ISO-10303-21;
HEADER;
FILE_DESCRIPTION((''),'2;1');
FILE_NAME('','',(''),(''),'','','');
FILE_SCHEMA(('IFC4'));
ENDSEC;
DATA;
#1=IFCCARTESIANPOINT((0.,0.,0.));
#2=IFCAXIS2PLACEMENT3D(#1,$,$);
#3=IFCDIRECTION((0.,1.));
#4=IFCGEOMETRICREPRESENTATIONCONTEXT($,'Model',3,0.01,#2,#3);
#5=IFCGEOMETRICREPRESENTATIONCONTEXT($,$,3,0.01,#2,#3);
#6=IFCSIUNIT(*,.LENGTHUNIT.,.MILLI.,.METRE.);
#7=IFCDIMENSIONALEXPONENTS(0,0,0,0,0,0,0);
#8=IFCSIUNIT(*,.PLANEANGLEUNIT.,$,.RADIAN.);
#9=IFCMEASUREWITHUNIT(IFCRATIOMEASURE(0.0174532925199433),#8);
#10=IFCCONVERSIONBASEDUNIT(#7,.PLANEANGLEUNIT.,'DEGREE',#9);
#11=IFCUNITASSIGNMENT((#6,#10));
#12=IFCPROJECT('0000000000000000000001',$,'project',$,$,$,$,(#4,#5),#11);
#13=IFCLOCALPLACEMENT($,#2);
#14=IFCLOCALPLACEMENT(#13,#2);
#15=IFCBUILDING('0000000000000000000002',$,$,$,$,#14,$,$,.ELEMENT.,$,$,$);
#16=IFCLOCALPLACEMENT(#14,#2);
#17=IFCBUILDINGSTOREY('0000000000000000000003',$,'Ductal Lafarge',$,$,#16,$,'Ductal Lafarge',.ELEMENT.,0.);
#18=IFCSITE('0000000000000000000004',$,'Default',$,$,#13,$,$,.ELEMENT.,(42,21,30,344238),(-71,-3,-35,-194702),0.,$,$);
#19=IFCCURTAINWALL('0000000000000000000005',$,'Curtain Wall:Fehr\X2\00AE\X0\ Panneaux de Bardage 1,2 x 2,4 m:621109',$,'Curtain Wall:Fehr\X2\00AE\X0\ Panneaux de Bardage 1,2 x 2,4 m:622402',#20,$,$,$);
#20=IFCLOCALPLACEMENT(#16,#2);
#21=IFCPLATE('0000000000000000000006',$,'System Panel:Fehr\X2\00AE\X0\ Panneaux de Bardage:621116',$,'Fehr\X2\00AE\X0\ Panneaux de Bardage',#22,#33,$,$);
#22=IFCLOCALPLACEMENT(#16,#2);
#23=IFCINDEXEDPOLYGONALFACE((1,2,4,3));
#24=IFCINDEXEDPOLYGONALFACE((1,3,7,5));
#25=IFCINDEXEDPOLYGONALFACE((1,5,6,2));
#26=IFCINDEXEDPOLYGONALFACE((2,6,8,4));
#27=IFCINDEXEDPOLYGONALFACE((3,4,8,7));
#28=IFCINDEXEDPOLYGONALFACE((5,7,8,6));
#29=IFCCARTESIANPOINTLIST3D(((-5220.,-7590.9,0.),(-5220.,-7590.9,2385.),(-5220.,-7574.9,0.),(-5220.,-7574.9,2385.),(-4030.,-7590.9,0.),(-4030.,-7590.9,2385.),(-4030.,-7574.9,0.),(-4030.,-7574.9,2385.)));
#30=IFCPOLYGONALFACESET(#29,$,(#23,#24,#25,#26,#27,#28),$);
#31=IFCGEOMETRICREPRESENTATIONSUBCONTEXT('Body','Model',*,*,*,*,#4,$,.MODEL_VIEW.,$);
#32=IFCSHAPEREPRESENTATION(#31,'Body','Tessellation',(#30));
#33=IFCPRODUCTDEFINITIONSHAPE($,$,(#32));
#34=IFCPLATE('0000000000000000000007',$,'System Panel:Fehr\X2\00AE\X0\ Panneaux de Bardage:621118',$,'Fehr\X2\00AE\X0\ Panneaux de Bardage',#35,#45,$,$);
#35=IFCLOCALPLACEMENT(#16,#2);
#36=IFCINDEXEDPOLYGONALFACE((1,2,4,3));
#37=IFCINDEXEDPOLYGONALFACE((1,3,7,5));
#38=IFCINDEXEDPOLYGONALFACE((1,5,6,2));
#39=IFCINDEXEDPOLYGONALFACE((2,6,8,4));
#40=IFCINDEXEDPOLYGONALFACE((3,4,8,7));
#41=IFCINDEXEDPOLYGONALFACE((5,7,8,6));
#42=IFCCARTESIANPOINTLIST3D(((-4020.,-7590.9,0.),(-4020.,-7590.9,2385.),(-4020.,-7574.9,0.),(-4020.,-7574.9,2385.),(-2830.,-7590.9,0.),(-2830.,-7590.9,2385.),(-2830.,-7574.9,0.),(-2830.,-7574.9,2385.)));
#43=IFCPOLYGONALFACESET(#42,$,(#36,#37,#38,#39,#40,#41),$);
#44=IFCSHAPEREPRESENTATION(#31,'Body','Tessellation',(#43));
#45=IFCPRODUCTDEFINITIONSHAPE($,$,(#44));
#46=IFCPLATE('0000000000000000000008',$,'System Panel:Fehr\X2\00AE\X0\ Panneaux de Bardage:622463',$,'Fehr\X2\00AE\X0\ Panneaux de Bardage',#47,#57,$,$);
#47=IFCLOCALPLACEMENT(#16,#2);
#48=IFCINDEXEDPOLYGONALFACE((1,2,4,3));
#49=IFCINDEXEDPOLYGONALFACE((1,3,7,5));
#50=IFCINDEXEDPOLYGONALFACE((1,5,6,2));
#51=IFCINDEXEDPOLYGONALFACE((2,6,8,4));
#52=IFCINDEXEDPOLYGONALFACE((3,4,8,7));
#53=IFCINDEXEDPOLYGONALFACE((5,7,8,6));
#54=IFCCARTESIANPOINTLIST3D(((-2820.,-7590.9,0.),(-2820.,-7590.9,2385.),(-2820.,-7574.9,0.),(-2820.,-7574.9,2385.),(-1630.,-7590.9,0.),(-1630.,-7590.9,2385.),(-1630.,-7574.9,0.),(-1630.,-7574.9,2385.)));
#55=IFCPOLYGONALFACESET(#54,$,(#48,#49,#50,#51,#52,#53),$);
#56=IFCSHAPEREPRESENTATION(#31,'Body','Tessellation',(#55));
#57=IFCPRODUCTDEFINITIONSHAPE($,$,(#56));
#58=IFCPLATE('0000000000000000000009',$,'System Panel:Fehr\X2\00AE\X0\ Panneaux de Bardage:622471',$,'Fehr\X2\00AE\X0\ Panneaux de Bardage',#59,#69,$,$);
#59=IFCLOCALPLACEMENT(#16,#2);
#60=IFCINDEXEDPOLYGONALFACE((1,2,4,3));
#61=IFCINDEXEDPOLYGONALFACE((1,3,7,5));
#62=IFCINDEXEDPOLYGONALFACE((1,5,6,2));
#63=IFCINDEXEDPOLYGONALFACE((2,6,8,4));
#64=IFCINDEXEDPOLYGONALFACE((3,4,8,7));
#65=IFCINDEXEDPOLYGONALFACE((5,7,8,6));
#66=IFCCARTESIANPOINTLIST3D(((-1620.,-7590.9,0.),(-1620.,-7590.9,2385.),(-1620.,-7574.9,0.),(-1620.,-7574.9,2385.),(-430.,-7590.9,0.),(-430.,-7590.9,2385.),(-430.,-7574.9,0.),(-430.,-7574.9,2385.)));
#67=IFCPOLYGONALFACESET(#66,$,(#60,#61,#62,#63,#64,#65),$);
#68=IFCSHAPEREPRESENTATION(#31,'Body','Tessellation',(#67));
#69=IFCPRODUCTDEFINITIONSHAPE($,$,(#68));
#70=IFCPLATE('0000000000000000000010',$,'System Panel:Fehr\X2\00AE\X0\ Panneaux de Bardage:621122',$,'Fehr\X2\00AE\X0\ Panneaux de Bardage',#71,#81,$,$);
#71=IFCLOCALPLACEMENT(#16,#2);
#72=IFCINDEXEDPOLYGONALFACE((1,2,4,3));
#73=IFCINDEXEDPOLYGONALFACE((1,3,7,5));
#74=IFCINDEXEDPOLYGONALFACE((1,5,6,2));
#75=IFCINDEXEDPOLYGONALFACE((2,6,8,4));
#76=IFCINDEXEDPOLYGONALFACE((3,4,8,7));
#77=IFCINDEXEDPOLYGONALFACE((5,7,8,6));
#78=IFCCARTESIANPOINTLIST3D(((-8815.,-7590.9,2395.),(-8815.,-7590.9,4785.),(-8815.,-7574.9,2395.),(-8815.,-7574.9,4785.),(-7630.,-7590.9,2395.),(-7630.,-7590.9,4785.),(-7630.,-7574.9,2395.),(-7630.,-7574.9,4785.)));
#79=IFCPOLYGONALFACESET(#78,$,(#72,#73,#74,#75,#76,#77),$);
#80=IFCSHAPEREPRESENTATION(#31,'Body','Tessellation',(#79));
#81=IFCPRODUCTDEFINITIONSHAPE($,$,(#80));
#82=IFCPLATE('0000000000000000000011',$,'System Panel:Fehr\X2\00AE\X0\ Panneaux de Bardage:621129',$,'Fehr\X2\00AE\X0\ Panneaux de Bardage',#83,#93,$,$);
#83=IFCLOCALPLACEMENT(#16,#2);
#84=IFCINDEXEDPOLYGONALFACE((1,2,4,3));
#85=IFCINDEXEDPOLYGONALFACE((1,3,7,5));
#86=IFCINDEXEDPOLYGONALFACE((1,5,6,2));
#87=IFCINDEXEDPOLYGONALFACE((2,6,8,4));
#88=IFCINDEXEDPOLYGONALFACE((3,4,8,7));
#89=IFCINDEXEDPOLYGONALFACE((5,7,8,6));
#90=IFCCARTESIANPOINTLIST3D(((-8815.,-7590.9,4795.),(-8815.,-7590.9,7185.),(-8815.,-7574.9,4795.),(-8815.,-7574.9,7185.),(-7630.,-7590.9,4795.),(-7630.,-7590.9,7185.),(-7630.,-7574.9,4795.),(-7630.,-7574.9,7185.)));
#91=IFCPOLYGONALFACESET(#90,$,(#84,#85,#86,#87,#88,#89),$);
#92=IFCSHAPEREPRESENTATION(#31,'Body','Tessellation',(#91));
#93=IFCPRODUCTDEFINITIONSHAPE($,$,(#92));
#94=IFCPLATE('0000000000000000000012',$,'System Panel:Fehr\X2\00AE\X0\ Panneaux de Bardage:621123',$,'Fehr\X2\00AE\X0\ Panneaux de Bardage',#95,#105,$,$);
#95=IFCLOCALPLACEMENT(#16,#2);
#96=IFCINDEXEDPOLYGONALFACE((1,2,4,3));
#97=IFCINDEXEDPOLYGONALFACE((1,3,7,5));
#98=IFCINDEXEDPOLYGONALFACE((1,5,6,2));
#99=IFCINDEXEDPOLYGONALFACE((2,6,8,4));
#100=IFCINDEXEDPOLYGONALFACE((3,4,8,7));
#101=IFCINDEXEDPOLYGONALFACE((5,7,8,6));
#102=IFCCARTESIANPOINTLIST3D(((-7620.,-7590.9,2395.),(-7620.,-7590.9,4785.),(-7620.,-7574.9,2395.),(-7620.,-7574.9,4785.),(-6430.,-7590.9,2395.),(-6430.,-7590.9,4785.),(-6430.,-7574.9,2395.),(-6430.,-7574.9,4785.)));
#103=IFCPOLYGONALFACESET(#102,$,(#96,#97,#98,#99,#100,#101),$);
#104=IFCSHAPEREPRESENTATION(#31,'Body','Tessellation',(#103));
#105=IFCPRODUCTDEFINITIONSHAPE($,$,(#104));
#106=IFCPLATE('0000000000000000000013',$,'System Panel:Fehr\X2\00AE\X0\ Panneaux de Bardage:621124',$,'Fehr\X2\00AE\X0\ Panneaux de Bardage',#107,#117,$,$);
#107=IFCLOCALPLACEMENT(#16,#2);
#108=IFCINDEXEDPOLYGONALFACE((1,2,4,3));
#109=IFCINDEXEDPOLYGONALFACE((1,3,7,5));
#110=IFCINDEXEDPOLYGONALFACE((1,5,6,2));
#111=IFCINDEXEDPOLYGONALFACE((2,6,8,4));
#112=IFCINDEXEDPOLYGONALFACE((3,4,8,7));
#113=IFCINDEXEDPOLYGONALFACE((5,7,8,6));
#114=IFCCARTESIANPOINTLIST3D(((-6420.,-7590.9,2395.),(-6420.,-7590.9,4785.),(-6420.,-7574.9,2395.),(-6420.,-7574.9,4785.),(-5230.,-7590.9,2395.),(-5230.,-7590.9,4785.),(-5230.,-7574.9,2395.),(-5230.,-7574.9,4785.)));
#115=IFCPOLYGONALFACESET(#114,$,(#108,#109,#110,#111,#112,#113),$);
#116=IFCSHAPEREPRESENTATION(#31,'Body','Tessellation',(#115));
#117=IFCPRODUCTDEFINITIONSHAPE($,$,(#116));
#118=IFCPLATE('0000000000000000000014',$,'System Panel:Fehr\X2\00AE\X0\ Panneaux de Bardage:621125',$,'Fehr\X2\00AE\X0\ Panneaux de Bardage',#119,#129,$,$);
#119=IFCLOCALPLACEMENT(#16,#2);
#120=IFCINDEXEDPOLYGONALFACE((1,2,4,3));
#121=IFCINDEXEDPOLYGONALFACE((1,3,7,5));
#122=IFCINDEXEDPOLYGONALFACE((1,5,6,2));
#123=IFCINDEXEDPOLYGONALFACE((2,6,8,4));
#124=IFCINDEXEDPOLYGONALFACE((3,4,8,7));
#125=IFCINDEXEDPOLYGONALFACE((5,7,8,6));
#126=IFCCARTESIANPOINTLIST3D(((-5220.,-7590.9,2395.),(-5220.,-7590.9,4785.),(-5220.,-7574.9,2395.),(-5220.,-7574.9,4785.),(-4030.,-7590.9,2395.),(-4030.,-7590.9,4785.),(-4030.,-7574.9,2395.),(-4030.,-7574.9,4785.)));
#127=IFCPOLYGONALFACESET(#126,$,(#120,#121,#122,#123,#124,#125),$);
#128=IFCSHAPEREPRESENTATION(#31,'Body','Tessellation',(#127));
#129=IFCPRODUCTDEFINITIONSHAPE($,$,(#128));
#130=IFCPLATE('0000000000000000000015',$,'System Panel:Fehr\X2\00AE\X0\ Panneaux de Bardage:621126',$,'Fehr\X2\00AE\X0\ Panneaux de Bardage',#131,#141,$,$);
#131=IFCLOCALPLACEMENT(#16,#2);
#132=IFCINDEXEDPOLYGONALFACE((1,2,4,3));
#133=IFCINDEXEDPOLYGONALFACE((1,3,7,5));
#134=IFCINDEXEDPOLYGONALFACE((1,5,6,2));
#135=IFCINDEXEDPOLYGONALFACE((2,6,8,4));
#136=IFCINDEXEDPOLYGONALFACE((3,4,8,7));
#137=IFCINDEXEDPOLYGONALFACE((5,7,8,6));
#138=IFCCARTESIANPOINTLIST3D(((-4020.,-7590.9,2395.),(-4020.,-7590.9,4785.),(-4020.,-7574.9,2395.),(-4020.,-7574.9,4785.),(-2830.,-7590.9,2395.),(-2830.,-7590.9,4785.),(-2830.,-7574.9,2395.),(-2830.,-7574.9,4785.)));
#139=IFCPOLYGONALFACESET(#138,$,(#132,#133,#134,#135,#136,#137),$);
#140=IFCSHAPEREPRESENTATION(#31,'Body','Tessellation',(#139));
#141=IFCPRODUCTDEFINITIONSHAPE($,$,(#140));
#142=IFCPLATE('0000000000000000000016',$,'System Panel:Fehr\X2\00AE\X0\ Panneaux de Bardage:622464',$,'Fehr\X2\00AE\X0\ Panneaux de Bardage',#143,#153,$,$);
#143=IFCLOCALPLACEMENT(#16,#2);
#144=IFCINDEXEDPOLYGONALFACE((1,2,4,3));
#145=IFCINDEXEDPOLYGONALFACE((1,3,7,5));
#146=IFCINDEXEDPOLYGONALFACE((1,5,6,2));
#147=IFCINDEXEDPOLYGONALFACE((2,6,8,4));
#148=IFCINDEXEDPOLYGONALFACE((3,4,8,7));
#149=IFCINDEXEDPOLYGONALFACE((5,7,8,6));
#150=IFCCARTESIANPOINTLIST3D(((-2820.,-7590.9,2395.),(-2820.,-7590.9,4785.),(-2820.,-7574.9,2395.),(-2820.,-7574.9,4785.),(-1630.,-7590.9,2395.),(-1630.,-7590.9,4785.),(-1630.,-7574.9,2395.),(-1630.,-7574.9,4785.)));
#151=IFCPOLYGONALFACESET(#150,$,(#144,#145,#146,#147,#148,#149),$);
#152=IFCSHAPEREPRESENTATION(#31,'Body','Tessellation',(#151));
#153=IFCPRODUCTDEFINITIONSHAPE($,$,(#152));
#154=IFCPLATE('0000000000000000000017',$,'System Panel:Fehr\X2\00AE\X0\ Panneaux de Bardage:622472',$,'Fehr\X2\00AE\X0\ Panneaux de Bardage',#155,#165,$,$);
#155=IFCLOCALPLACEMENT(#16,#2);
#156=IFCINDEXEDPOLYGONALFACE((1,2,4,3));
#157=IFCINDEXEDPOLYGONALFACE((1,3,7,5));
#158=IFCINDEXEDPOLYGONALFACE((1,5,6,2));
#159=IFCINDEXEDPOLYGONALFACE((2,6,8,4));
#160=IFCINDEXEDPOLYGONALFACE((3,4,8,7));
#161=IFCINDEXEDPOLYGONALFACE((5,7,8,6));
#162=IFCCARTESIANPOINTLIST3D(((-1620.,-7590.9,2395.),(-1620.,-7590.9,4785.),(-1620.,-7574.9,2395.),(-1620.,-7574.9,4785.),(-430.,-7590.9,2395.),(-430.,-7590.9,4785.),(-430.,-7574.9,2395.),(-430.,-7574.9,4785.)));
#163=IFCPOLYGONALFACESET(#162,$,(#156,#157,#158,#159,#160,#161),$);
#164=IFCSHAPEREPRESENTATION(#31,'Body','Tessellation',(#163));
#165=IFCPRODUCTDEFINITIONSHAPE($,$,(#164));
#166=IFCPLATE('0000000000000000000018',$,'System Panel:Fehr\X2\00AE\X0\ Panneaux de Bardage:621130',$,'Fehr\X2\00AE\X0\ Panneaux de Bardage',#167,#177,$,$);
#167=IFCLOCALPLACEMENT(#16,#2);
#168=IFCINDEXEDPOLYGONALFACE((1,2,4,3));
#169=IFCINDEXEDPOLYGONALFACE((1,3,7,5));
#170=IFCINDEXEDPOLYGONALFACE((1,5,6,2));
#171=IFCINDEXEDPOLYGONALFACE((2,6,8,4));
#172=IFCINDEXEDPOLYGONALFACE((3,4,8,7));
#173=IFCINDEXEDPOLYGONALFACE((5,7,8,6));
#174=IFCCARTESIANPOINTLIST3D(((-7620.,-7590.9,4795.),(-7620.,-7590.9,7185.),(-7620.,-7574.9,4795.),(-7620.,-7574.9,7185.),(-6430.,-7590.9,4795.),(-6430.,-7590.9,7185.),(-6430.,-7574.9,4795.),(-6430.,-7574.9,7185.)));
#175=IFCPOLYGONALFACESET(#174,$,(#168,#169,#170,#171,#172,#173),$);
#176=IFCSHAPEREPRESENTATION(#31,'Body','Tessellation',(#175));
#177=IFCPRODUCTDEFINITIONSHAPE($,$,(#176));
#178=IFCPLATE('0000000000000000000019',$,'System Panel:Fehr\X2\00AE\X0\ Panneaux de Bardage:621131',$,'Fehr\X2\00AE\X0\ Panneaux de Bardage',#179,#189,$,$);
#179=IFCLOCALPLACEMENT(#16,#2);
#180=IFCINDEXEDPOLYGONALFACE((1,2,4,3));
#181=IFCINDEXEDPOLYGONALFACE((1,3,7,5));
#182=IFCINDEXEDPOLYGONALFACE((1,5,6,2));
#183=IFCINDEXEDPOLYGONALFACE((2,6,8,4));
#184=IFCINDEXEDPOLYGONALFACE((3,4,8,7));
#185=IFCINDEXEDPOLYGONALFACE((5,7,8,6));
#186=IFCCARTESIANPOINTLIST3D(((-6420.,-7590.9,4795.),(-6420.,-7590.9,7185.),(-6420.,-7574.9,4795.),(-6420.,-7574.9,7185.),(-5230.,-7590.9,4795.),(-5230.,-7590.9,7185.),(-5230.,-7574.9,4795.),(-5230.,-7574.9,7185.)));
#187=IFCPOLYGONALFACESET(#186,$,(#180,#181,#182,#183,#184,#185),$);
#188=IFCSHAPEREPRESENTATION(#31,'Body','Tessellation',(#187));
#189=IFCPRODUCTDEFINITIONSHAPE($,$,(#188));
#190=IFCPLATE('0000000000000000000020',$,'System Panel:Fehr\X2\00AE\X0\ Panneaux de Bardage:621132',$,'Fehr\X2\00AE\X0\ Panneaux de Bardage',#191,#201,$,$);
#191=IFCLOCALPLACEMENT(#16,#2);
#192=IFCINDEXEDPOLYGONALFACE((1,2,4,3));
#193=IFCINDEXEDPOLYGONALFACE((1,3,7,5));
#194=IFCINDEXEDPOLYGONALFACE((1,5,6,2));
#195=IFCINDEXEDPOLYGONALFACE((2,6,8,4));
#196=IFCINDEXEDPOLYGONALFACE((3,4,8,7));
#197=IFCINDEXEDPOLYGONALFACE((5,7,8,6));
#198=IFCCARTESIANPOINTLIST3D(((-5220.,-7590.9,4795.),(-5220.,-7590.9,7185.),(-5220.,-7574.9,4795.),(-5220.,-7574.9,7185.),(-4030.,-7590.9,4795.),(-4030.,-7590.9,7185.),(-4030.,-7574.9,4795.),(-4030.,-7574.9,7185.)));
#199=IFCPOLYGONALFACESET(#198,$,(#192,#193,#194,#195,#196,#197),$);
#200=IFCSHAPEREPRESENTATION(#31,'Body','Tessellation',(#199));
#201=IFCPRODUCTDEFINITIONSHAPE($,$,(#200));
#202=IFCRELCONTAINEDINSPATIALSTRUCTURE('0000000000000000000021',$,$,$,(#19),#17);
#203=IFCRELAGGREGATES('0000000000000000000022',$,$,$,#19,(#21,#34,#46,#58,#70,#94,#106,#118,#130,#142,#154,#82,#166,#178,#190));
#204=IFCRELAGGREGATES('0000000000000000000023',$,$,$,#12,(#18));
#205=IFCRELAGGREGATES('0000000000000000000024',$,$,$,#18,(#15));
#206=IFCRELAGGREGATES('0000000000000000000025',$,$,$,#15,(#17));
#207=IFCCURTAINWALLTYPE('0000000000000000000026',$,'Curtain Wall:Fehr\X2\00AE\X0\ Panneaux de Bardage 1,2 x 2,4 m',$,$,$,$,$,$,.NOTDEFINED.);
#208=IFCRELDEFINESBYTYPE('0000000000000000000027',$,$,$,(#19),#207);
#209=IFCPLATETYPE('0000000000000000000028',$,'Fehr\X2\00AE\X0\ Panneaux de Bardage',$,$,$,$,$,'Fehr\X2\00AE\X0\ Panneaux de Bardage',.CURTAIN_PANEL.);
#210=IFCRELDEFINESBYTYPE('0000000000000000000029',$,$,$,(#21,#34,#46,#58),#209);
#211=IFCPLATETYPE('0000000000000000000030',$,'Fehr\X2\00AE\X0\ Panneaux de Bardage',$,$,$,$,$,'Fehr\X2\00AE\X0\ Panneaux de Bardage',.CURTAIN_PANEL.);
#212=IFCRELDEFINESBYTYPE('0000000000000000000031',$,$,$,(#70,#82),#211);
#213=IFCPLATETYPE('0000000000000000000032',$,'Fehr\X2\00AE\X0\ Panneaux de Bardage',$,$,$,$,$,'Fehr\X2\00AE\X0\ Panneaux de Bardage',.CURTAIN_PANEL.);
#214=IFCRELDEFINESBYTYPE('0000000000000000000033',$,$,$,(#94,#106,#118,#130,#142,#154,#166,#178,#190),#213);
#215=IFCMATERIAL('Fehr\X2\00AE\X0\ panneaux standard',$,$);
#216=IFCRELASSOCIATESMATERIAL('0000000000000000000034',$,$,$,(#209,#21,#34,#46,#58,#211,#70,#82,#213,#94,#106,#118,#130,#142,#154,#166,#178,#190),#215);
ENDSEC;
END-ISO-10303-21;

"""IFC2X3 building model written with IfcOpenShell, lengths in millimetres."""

from ifc_helpers import new_model, entity, si_unit, converted_unit, direction, frame, origin, origin_2d_with_axis, place, context, subcontext, project, spatial, rectangle, extrude, source, transform, mapped, material, type_object, type_shapes, element, aggregate, save


model = new_model("IFC2X3")

# Units and contexts
model_context = context("Model", 3, precision=0.01, world=origin(), true_north=direction((0.0, 1.0)))
context_of_model = context(None, 3, precision=0.01, world=origin(), true_north=direction((0.0, 1.0)))
body_context = subcontext(model_context, "Body", "Model", "MODEL_VIEW")
ifc_project = project(units=[si_unit("LENGTHUNIT", "METRE", prefix="MILLI"), converted_unit("PLANEANGLEUNIT", "DEGREE", entity("IfcRatioMeasure", 0.0174532925199433), si_unit("PLANEANGLEUNIT", "RADIAN"), dimensions=[0, 0, 0, 0, 0, 0, 0])], contexts=[model_context, context_of_model])

# Site, building, storey
site_placement = place(None, origin())
site = spatial("IfcSite", under=ifc_project, at=site_placement, Name="Default", CompositionType="ELEMENT", RefLatitude=(42, 21, 30, 344238), RefLongitude=(-71, -3, -35, -194702), RefElevation=0.0)
building_placement = place(site_placement, origin())
building = spatial("IfcBuilding", under=site, at=building_placement, CompositionType="ELEMENT")
storey_placement = place(building_placement, origin())
storey = spatial("IfcBuildingStorey", under=building, at=storey_placement, Name="Ductal Lafarge", LongName="Ductal Lafarge", CompositionType="ELEMENT", Elevation=0.0)

# Curtain wall
ifc_material_1 = material(Name="Fehr® panneaux standard")
curtain_wall_type_1 = type_object("IfcCurtainWallType", Name="Curtain Wall:Fehr® Panneaux de Bardage 1,2 x 2,4 m", PredefinedType="NOTDEFINED")
curtain_wall_1_placement = place(storey_placement, origin())
curtain_wall_1 = element("IfcCurtainWall", 1, at=curtain_wall_1_placement, inside=storey, type_object=curtain_wall_type_1, Name="Curtain Wall:Fehr® Panneaux de Bardage 1,2 x 2,4 m:621109", ObjectType="Curtain Wall:Fehr® Panneaux de Bardage 1,2 x 2,4 m:622402")

# Plates
plate_type_1 = type_object("IfcPlateType", Name="Fehr® Panneaux de Bardage", ElementType="Fehr® Panneaux de Bardage", PredefinedType="CURTAIN_PANEL", material=ifc_material_1)
shared_shape_1 = source(origin(), body_context, "Body", "SweptSolid", [
    extrude(rectangle(XDim=16.0, YDim=1190.0, at=origin_2d_with_axis()), frame((0.0, 0.0, 0.0), z_axis=(0.0, 0.0, 1.0), x_axis=(0.0, 1.0, 0.0)), (0.0, 0.0, 1.0), 2385.0),
])
type_shapes(plate_type_1, [shared_shape_1])
plate_1_placement = place(curtain_wall_1_placement, frame((-4625.0, -7582.9, 0.0)))
plate_1 = element("IfcPlate", 2, at=plate_1_placement, type_object=plate_type_1, material=ifc_material_1, Name="System Panel:Fehr® Panneaux de Bardage:621116", ObjectType="Fehr® Panneaux de Bardage", context=body_context, shape_type="MappedRepresentation", body=[
    mapped(shared_shape_1, transform((0.0, 0.0, 0.0), scale=1.0)),
])
plate_2_placement = place(curtain_wall_1_placement, frame((-3425.0, -7582.9, 0.0)))
plate_2 = element("IfcPlate", 3, at=plate_2_placement, type_object=plate_type_1, material=ifc_material_1, Name="System Panel:Fehr® Panneaux de Bardage:621118", ObjectType="Fehr® Panneaux de Bardage", context=body_context, shape_type="MappedRepresentation", body=[
    mapped(shared_shape_1, transform((0.0, 0.0, 0.0), scale=1.0)),
])
plate_3_placement = place(curtain_wall_1_placement, frame((-2225.0, -7582.9, 0.0)))
plate_3 = element("IfcPlate", 4, at=plate_3_placement, type_object=plate_type_1, material=ifc_material_1, Name="System Panel:Fehr® Panneaux de Bardage:622463", ObjectType="Fehr® Panneaux de Bardage", context=body_context, shape_type="MappedRepresentation", body=[
    mapped(shared_shape_1, transform((0.0, 0.0, 0.0), scale=1.0)),
])
plate_4_placement = place(curtain_wall_1_placement, frame((-1025.0, -7582.9, 0.0)))
plate_4 = element("IfcPlate", 5, at=plate_4_placement, type_object=plate_type_1, material=ifc_material_1, Name="System Panel:Fehr® Panneaux de Bardage:622471", ObjectType="Fehr® Panneaux de Bardage", context=body_context, shape_type="MappedRepresentation", body=[
    mapped(shared_shape_1, transform((0.0, 0.0, 0.0), scale=1.0)),
])
plate_type_2 = type_object("IfcPlateType", Name="Fehr® Panneaux de Bardage", ElementType="Fehr® Panneaux de Bardage", PredefinedType="CURTAIN_PANEL", material=ifc_material_1)
shared_shape_2 = source(origin(), body_context, "Body", "SweptSolid", [
    extrude(rectangle(XDim=16.0, YDim=1185.0, at=origin_2d_with_axis()), frame((0.0, 0.0, 0.0), z_axis=(0.0, 0.0, 1.0), x_axis=(0.0, 1.0, 0.0)), (0.0, 0.0, 1.0), 2390.0),
])
type_shapes(plate_type_2, [shared_shape_2])
plate_5_placement = place(curtain_wall_1_placement, frame((-8222.5, -7582.9, 2395.0)))
plate_5 = element("IfcPlate", 6, at=plate_5_placement, type_object=plate_type_2, material=ifc_material_1, Name="System Panel:Fehr® Panneaux de Bardage:621122", ObjectType="Fehr® Panneaux de Bardage", context=body_context, shape_type="MappedRepresentation", body=[
    mapped(shared_shape_2, transform((0.0, 0.0, 0.0), scale=1.0)),
])
plate_6_placement = place(curtain_wall_1_placement, frame((-8222.5, -7582.9, 4795.0)))
plate_6 = element("IfcPlate", 7, at=plate_6_placement, type_object=plate_type_2, material=ifc_material_1, Name="System Panel:Fehr® Panneaux de Bardage:621129", ObjectType="Fehr® Panneaux de Bardage", context=body_context, shape_type="MappedRepresentation", body=[
    mapped(shared_shape_2, transform((0.0, 0.0, 0.0), scale=1.0)),
])
plate_type_3 = type_object("IfcPlateType", Name="Fehr® Panneaux de Bardage", ElementType="Fehr® Panneaux de Bardage", PredefinedType="CURTAIN_PANEL", material=ifc_material_1)
shared_shape_3 = source(origin(), body_context, "Body", "SweptSolid", [
    extrude(rectangle(XDim=16.0, YDim=1190.0, at=origin_2d_with_axis()), frame((0.0, 0.0, 0.0), z_axis=(0.0, 0.0, 1.0), x_axis=(0.0, 1.0, 0.0)), (0.0, 0.0, 1.0), 2390.0),
])
type_shapes(plate_type_3, [shared_shape_3])
plate_7_placement = place(curtain_wall_1_placement, frame((-7025.0, -7582.9, 2395.0)))
plate_7 = element("IfcPlate", 8, at=plate_7_placement, type_object=plate_type_3, material=ifc_material_1, Name="System Panel:Fehr® Panneaux de Bardage:621123", ObjectType="Fehr® Panneaux de Bardage", context=body_context, shape_type="MappedRepresentation", body=[
    mapped(shared_shape_3, transform((0.0, 0.0, 0.0), scale=1.0)),
])
plate_8_placement = place(curtain_wall_1_placement, frame((-5825.0, -7582.9, 2395.0)))
plate_8 = element("IfcPlate", 9, at=plate_8_placement, type_object=plate_type_3, material=ifc_material_1, Name="System Panel:Fehr® Panneaux de Bardage:621124", ObjectType="Fehr® Panneaux de Bardage", context=body_context, shape_type="MappedRepresentation", body=[
    mapped(shared_shape_3, transform((0.0, 0.0, 0.0), scale=1.0)),
])
plate_9_placement = place(curtain_wall_1_placement, frame((-4625.0, -7582.9, 2395.0)))
plate_9 = element("IfcPlate", 10, at=plate_9_placement, type_object=plate_type_3, material=ifc_material_1, Name="System Panel:Fehr® Panneaux de Bardage:621125", ObjectType="Fehr® Panneaux de Bardage", context=body_context, shape_type="MappedRepresentation", body=[
    mapped(shared_shape_3, transform((0.0, 0.0, 0.0), scale=1.0)),
])
plate_10_placement = place(curtain_wall_1_placement, frame((-3425.0, -7582.9, 2395.0)))
plate_10 = element("IfcPlate", 11, at=plate_10_placement, type_object=plate_type_3, material=ifc_material_1, Name="System Panel:Fehr® Panneaux de Bardage:621126", ObjectType="Fehr® Panneaux de Bardage", context=body_context, shape_type="MappedRepresentation", body=[
    mapped(shared_shape_3, transform((0.0, 0.0, 0.0), scale=1.0)),
])
plate_11_placement = place(curtain_wall_1_placement, frame((-2225.0, -7582.9, 2395.0)))
plate_11 = element("IfcPlate", 12, at=plate_11_placement, type_object=plate_type_3, material=ifc_material_1, Name="System Panel:Fehr® Panneaux de Bardage:622464", ObjectType="Fehr® Panneaux de Bardage", context=body_context, shape_type="MappedRepresentation", body=[
    mapped(shared_shape_3, transform((0.0, 0.0, 0.0), scale=1.0)),
])
plate_12_placement = place(curtain_wall_1_placement, frame((-1025.0, -7582.9, 2395.0)))
plate_12 = element("IfcPlate", 13, at=plate_12_placement, type_object=plate_type_3, material=ifc_material_1, Name="System Panel:Fehr® Panneaux de Bardage:622472", ObjectType="Fehr® Panneaux de Bardage", context=body_context, shape_type="MappedRepresentation", body=[
    mapped(shared_shape_3, transform((0.0, 0.0, 0.0), scale=1.0)),
])
plate_13_placement = place(curtain_wall_1_placement, frame((-7025.0, -7582.9, 4795.0)))
plate_13 = element("IfcPlate", 14, at=plate_13_placement, type_object=plate_type_3, material=ifc_material_1, Name="System Panel:Fehr® Panneaux de Bardage:621130", ObjectType="Fehr® Panneaux de Bardage", context=body_context, shape_type="MappedRepresentation", body=[
    mapped(shared_shape_3, transform((0.0, 0.0, 0.0), scale=1.0)),
])
plate_14_placement = place(curtain_wall_1_placement, frame((-5825.0, -7582.9, 4795.0)))
plate_14 = element("IfcPlate", 15, at=plate_14_placement, type_object=plate_type_3, material=ifc_material_1, Name="System Panel:Fehr® Panneaux de Bardage:621131", ObjectType="Fehr® Panneaux de Bardage", context=body_context, shape_type="MappedRepresentation", body=[
    mapped(shared_shape_3, transform((0.0, 0.0, 0.0), scale=1.0)),
])
plate_15_placement = place(curtain_wall_1_placement, frame((-4625.0, -7582.9, 4795.0)))
plate_15 = element("IfcPlate", 16, at=plate_15_placement, type_object=plate_type_3, material=ifc_material_1, Name="System Panel:Fehr® Panneaux de Bardage:621132", ObjectType="Fehr® Panneaux de Bardage", context=body_context, shape_type="MappedRepresentation", body=[
    mapped(shared_shape_3, transform((0.0, 0.0, 0.0), scale=1.0)),
])
aggregate(curtain_wall_1, [plate_1, plate_2, plate_3, plate_4, plate_5, plate_7, plate_8, plate_9, plate_10, plate_11, plate_12, plate_6, plate_13, plate_14, plate_15])

save(model, "model.ifc")
